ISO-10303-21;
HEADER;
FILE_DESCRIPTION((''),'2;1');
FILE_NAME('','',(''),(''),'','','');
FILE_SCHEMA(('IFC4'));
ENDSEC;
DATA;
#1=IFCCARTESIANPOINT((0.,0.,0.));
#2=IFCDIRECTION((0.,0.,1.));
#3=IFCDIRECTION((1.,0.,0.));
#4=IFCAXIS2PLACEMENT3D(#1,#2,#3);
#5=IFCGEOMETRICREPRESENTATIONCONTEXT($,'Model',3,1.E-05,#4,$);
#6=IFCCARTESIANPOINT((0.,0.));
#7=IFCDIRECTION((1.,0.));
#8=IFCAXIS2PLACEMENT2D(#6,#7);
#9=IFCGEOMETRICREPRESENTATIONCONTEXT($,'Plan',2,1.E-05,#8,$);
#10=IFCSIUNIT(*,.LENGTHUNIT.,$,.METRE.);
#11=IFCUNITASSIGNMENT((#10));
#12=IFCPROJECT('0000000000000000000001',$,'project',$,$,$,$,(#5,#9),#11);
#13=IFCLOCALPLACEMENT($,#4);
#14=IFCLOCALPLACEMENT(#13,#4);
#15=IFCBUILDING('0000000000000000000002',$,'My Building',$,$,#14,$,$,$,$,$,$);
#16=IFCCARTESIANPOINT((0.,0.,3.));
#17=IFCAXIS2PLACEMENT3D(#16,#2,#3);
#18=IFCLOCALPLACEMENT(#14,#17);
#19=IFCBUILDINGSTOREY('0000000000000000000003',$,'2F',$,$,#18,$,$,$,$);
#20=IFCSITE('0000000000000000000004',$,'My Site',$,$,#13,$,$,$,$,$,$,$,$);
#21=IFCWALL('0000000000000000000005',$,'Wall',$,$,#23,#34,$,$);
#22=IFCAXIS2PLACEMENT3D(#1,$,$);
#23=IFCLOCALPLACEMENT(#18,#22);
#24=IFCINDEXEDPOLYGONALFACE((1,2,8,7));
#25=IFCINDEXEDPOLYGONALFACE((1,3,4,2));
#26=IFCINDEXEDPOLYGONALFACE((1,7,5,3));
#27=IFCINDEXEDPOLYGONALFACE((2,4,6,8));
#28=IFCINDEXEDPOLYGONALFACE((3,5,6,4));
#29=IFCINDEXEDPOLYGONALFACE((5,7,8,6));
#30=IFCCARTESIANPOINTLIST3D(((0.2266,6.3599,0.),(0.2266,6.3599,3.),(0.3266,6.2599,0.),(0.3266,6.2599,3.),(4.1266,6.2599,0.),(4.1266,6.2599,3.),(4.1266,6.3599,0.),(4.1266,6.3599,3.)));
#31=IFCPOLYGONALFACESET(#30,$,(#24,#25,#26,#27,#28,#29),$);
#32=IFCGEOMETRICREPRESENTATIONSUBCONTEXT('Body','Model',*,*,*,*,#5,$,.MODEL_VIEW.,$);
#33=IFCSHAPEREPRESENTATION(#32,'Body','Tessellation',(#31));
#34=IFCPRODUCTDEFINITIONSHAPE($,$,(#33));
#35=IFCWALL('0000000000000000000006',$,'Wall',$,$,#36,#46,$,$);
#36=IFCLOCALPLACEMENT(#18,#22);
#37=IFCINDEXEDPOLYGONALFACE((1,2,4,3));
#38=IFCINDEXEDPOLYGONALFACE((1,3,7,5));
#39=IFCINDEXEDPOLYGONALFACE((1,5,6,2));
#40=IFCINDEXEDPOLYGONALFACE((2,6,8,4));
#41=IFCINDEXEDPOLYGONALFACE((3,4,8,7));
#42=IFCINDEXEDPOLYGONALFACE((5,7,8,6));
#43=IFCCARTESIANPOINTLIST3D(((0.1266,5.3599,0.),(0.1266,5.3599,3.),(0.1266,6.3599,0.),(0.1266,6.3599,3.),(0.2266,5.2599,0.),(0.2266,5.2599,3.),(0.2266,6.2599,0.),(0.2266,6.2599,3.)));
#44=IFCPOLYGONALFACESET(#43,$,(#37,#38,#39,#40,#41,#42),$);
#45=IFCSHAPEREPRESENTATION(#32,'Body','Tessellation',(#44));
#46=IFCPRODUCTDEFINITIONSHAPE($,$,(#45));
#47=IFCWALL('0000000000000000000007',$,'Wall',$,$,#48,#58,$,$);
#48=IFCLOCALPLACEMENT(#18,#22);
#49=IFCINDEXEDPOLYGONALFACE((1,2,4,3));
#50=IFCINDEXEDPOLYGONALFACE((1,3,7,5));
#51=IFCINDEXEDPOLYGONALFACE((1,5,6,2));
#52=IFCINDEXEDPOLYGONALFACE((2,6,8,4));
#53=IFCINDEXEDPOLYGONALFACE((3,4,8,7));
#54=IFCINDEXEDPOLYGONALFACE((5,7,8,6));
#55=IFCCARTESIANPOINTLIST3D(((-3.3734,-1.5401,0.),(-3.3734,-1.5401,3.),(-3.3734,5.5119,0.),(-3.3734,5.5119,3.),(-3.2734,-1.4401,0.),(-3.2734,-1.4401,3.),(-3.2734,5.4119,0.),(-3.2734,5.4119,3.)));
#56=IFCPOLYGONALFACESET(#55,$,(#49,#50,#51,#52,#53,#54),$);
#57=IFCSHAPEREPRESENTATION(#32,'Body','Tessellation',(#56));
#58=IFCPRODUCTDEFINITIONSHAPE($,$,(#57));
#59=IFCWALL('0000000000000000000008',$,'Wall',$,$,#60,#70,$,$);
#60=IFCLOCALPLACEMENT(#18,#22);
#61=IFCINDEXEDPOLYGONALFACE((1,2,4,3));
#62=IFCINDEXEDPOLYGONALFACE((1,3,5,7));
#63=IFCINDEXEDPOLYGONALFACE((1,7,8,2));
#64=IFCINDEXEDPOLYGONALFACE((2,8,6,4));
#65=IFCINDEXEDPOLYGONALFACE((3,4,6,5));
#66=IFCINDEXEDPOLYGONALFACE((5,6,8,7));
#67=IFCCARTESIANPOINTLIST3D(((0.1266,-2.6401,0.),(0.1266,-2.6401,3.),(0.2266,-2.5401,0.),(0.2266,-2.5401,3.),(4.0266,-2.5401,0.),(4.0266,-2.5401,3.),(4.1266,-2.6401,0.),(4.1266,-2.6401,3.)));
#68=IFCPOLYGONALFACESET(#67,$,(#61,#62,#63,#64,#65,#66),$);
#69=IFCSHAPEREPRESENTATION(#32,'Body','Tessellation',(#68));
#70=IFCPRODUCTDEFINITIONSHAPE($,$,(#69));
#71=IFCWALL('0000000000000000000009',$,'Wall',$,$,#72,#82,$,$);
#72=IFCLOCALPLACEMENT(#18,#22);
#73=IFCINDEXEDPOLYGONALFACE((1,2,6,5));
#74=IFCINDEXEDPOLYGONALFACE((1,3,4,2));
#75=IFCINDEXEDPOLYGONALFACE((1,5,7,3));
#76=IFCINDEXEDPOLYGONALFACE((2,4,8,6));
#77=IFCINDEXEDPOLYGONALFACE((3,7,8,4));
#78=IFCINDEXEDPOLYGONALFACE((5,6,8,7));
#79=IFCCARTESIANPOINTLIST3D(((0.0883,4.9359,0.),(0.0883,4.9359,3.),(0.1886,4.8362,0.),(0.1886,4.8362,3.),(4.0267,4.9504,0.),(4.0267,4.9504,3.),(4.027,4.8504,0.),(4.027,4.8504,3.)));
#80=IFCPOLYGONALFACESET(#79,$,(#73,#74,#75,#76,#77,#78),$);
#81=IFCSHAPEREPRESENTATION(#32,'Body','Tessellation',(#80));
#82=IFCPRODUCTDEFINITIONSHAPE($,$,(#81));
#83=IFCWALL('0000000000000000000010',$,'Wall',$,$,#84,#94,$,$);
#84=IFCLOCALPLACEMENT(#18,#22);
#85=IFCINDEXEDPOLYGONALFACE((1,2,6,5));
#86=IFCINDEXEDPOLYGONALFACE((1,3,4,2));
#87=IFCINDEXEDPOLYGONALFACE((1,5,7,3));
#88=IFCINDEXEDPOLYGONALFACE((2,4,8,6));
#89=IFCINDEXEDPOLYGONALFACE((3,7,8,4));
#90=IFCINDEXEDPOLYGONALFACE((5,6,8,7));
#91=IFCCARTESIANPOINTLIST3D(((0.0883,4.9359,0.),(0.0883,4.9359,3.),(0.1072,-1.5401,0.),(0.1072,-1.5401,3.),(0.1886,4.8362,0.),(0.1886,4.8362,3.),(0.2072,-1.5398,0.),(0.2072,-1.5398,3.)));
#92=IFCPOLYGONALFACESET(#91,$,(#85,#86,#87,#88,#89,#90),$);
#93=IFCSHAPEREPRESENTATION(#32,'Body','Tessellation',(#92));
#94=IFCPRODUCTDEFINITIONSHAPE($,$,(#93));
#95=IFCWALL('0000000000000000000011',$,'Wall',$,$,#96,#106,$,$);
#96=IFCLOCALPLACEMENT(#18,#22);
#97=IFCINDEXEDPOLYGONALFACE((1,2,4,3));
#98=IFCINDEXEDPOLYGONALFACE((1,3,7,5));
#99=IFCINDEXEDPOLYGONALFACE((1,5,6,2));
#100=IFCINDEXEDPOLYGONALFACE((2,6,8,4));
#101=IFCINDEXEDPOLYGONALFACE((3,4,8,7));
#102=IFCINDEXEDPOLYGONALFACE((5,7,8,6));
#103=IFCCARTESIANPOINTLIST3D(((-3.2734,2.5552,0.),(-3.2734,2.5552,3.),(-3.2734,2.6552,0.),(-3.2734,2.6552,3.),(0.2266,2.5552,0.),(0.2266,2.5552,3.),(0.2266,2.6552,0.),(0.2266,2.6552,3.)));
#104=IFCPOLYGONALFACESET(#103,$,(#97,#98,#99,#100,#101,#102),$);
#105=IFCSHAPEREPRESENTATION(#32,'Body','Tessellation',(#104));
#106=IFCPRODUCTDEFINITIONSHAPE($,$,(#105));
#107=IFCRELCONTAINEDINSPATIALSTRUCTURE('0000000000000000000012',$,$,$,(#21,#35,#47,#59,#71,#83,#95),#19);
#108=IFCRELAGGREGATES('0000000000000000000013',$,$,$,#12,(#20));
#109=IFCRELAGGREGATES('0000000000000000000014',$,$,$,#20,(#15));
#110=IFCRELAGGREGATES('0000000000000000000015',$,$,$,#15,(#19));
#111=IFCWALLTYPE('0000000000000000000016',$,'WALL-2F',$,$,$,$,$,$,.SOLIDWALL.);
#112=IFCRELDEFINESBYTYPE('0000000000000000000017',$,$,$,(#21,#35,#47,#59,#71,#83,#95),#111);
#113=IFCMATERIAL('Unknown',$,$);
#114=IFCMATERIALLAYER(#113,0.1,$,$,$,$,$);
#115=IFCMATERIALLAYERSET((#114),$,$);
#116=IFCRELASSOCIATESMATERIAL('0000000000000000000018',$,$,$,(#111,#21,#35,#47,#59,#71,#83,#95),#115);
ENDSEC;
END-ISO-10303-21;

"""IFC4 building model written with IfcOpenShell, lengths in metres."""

from ifc_helpers import new_model, si_unit, frame, origin_with_axes, origin_2d_with_axis, place, context, subcontext, project, spatial, line, indexed_curve, outline, extrude, material, layer, layer_set, layer_usage, type_object, element, save


model = new_model("IFC4")

# Units and contexts
model_context = context("Model", 3, precision=1e-05, world=origin_with_axes())
plan_context = context("Plan", 2, precision=1e-05, world=origin_2d_with_axis())
body_context_1 = subcontext(model_context, "Body", "Model", "MODEL_VIEW")
ifc_project = project(units=[si_unit("LENGTHUNIT", "METRE")], contexts=[model_context, plan_context])

# Site, building, storey
site_placement = place(None, origin_with_axes())
site = spatial("IfcSite", under=ifc_project, at=site_placement, Name="My Site")
building_placement = place(site_placement, origin_with_axes())
building = spatial("IfcBuilding", under=site, at=building_placement, Name="My Building")
storey_placement = place(building_placement, frame((0.0, 0.0, 3.0), z_axis=(0.0, 0.0, 1.0), x_axis=(1.0, 0.0, 0.0)))
storey = spatial("IfcBuildingStorey", under=building, at=storey_placement, Name="2F")

# Shared definitions
ifc_material = material(Name="Unknown")

# Shared definitions
ifc_layer_1 = layer(ifc_material, 0.1)
ifc_layer_set_1 = layer_set([ifc_layer_1])
wall_type = type_object("IfcWallType", Name="WALL-2F", PredefinedType="SOLIDWALL", material=ifc_layer_set_1)

# Walls
ifc_layer_usage_1 = layer_usage(ifc_layer_set_1, "AXIS2", "POSITIVE", 0.0)
wall_1_placement = place(storey_placement, frame((4.1266, 6.3599, 0.0), z_axis=(0.0, 0.0, 1.0), x_axis=(-1.0, 0.0, 0.0)))
element("IfcWall", 1, at=wall_1_placement, inside=storey, type_object=wall_type, material=ifc_layer_usage_1, Name="Wall", context=body_context_1, shape_type="SweptSolid", body=[
    extrude(outline(indexed_curve([(0.0, 0.0), (0.0, 0.1), (3.8, 0.1), (3.9, 0.0)], segments=[line(1, 2, 3, 4, 1)])), origin_with_axes(), (0.0, 0.0, 1.0), 3.0),
])
ifc_layer_usage_2 = layer_usage(ifc_layer_set_1, "AXIS2", "POSITIVE", 0.0)
wall_2_placement = place(storey_placement, frame((0.1266, 6.3599, 0.0), z_axis=(0.0, 0.0, 1.0), x_axis=(0.0, -1.0, 0.0)))
element("IfcWall", 2, at=wall_2_placement, inside=storey, type_object=wall_type, material=ifc_layer_usage_2, Name="Wall", context=body_context_1, shape_type="SweptSolid", body=[
    extrude(outline(indexed_curve([(0.0, 0.0), (0.1, 0.1), (1.1, 0.1), (1.0, 0.0)], segments=[line(1, 2, 3, 4, 1)])), origin_with_axes(), (0.0, 0.0, 1.0), 3.0),
])
ifc_layer_usage_3 = layer_usage(ifc_layer_set_1, "AXIS2", "POSITIVE", 0.0)
wall_3_placement = place(storey_placement, frame((-3.3734, 5.5119, 0.0), z_axis=(0.0, 0.0, 1.0), x_axis=(0.0, -1.0, 0.0)))
element("IfcWall", 3, at=wall_3_placement, inside=storey, type_object=wall_type, material=ifc_layer_usage_3, Name="Wall", context=body_context_1, shape_type="SweptSolid", body=[
    extrude(outline(indexed_curve([(0.0, 0.0), (0.1, 0.1), (6.952, 0.1), (7.0521, 0.0)], segments=[line(1, 2, 3, 4, 1)])), origin_with_axes(), (0.0, 0.0, 1.0), 3.0),
])
ifc_layer_usage_4 = layer_usage(ifc_layer_set_1, "AXIS2", "POSITIVE", 0.0)
wall_4_placement = place(storey_placement, frame((0.1266, -2.6401, 0.0), z_axis=(0.0, 0.0, 1.0), x_axis=(1.0, 0.0, 0.0)))
element("IfcWall", 4, at=wall_4_placement, inside=storey, type_object=wall_type, material=ifc_layer_usage_4, Name="Wall", context=body_context_1, shape_type="SweptSolid", body=[
    extrude(outline(indexed_curve([(0.0, 0.0), (0.1, 0.1), (3.9, 0.1), (4.0, 0.0)], segments=[line(1, 2, 3, 4, 1)])), origin_with_axes(), (0.0, 0.0, 1.0), 3.0),
])
ifc_layer_usage_5 = layer_usage(ifc_layer_set_1, "AXIS2", "POSITIVE", 0.0)
wall_5_placement = place(storey_placement, frame((4.0267, 4.9504, 0.0), z_axis=(0.0, 0.0, 1.0), x_axis=(-0.999993, -0.003677, 0.0)))
element("IfcWall", 5, at=wall_5_placement, inside=storey, type_object=wall_type, material=ifc_layer_usage_5, Name="Wall", context=body_context_1, shape_type="SweptSolid", body=[
    extrude(outline(indexed_curve([(0.0, 0.0), (0.0, 0.1), (3.8384, 0.1), (3.9383, 0.0)], segments=[line(1, 2, 3, 4, 1)])), origin_with_axes(), (0.0, 0.0, 1.0), 3.0),
])
ifc_layer_usage_6 = layer_usage(ifc_layer_set_1, "AXIS2", "POSITIVE", 0.0)
wall_6_placement = place(storey_placement, frame((0.0883, 4.9359, 0.0), z_axis=(0.0, 0.0, 1.0), x_axis=(0.00292, -0.999996, 0.0)))
element("IfcWall", 6, at=wall_6_placement, inside=storey, type_object=wall_type, material=ifc_layer_usage_6, Name="Wall", context=body_context_1, shape_type="SweptSolid", body=[
    extrude(outline(indexed_curve([(0.0, 0.0), (0.0999, 0.1), (6.476, 0.1), (6.476, 0.0)], segments=[line(1, 2, 3, 4, 1)])), origin_with_axes(), (0.0, 0.0, 1.0), 3.0),
])
ifc_layer_usage_7 = layer_usage(ifc_layer_set_1, "AXIS2", "POSITIVE", 0.0)
wall_7_placement = place(storey_placement, frame((-3.2734, 2.5552, 0.0), z_axis=(0.0, 0.0, 1.0), x_axis=(1.0, 0.0, 0.0)))
element("IfcWall", 7, at=wall_7_placement, inside=storey, type_object=wall_type, material=ifc_layer_usage_7, Name="Wall", context=body_context_1, shape_type="SweptSolid", body=[
    extrude(outline(indexed_curve([(0.0, 0.0), (0.0, 0.1), (3.5, 0.1), (3.5, 0.0)], segments=[line(1, 2, 3, 4, 1)])), origin_with_axes(), (0.0, 0.0, 1.0), 3.0),
])

save(model, "model.ifc")
